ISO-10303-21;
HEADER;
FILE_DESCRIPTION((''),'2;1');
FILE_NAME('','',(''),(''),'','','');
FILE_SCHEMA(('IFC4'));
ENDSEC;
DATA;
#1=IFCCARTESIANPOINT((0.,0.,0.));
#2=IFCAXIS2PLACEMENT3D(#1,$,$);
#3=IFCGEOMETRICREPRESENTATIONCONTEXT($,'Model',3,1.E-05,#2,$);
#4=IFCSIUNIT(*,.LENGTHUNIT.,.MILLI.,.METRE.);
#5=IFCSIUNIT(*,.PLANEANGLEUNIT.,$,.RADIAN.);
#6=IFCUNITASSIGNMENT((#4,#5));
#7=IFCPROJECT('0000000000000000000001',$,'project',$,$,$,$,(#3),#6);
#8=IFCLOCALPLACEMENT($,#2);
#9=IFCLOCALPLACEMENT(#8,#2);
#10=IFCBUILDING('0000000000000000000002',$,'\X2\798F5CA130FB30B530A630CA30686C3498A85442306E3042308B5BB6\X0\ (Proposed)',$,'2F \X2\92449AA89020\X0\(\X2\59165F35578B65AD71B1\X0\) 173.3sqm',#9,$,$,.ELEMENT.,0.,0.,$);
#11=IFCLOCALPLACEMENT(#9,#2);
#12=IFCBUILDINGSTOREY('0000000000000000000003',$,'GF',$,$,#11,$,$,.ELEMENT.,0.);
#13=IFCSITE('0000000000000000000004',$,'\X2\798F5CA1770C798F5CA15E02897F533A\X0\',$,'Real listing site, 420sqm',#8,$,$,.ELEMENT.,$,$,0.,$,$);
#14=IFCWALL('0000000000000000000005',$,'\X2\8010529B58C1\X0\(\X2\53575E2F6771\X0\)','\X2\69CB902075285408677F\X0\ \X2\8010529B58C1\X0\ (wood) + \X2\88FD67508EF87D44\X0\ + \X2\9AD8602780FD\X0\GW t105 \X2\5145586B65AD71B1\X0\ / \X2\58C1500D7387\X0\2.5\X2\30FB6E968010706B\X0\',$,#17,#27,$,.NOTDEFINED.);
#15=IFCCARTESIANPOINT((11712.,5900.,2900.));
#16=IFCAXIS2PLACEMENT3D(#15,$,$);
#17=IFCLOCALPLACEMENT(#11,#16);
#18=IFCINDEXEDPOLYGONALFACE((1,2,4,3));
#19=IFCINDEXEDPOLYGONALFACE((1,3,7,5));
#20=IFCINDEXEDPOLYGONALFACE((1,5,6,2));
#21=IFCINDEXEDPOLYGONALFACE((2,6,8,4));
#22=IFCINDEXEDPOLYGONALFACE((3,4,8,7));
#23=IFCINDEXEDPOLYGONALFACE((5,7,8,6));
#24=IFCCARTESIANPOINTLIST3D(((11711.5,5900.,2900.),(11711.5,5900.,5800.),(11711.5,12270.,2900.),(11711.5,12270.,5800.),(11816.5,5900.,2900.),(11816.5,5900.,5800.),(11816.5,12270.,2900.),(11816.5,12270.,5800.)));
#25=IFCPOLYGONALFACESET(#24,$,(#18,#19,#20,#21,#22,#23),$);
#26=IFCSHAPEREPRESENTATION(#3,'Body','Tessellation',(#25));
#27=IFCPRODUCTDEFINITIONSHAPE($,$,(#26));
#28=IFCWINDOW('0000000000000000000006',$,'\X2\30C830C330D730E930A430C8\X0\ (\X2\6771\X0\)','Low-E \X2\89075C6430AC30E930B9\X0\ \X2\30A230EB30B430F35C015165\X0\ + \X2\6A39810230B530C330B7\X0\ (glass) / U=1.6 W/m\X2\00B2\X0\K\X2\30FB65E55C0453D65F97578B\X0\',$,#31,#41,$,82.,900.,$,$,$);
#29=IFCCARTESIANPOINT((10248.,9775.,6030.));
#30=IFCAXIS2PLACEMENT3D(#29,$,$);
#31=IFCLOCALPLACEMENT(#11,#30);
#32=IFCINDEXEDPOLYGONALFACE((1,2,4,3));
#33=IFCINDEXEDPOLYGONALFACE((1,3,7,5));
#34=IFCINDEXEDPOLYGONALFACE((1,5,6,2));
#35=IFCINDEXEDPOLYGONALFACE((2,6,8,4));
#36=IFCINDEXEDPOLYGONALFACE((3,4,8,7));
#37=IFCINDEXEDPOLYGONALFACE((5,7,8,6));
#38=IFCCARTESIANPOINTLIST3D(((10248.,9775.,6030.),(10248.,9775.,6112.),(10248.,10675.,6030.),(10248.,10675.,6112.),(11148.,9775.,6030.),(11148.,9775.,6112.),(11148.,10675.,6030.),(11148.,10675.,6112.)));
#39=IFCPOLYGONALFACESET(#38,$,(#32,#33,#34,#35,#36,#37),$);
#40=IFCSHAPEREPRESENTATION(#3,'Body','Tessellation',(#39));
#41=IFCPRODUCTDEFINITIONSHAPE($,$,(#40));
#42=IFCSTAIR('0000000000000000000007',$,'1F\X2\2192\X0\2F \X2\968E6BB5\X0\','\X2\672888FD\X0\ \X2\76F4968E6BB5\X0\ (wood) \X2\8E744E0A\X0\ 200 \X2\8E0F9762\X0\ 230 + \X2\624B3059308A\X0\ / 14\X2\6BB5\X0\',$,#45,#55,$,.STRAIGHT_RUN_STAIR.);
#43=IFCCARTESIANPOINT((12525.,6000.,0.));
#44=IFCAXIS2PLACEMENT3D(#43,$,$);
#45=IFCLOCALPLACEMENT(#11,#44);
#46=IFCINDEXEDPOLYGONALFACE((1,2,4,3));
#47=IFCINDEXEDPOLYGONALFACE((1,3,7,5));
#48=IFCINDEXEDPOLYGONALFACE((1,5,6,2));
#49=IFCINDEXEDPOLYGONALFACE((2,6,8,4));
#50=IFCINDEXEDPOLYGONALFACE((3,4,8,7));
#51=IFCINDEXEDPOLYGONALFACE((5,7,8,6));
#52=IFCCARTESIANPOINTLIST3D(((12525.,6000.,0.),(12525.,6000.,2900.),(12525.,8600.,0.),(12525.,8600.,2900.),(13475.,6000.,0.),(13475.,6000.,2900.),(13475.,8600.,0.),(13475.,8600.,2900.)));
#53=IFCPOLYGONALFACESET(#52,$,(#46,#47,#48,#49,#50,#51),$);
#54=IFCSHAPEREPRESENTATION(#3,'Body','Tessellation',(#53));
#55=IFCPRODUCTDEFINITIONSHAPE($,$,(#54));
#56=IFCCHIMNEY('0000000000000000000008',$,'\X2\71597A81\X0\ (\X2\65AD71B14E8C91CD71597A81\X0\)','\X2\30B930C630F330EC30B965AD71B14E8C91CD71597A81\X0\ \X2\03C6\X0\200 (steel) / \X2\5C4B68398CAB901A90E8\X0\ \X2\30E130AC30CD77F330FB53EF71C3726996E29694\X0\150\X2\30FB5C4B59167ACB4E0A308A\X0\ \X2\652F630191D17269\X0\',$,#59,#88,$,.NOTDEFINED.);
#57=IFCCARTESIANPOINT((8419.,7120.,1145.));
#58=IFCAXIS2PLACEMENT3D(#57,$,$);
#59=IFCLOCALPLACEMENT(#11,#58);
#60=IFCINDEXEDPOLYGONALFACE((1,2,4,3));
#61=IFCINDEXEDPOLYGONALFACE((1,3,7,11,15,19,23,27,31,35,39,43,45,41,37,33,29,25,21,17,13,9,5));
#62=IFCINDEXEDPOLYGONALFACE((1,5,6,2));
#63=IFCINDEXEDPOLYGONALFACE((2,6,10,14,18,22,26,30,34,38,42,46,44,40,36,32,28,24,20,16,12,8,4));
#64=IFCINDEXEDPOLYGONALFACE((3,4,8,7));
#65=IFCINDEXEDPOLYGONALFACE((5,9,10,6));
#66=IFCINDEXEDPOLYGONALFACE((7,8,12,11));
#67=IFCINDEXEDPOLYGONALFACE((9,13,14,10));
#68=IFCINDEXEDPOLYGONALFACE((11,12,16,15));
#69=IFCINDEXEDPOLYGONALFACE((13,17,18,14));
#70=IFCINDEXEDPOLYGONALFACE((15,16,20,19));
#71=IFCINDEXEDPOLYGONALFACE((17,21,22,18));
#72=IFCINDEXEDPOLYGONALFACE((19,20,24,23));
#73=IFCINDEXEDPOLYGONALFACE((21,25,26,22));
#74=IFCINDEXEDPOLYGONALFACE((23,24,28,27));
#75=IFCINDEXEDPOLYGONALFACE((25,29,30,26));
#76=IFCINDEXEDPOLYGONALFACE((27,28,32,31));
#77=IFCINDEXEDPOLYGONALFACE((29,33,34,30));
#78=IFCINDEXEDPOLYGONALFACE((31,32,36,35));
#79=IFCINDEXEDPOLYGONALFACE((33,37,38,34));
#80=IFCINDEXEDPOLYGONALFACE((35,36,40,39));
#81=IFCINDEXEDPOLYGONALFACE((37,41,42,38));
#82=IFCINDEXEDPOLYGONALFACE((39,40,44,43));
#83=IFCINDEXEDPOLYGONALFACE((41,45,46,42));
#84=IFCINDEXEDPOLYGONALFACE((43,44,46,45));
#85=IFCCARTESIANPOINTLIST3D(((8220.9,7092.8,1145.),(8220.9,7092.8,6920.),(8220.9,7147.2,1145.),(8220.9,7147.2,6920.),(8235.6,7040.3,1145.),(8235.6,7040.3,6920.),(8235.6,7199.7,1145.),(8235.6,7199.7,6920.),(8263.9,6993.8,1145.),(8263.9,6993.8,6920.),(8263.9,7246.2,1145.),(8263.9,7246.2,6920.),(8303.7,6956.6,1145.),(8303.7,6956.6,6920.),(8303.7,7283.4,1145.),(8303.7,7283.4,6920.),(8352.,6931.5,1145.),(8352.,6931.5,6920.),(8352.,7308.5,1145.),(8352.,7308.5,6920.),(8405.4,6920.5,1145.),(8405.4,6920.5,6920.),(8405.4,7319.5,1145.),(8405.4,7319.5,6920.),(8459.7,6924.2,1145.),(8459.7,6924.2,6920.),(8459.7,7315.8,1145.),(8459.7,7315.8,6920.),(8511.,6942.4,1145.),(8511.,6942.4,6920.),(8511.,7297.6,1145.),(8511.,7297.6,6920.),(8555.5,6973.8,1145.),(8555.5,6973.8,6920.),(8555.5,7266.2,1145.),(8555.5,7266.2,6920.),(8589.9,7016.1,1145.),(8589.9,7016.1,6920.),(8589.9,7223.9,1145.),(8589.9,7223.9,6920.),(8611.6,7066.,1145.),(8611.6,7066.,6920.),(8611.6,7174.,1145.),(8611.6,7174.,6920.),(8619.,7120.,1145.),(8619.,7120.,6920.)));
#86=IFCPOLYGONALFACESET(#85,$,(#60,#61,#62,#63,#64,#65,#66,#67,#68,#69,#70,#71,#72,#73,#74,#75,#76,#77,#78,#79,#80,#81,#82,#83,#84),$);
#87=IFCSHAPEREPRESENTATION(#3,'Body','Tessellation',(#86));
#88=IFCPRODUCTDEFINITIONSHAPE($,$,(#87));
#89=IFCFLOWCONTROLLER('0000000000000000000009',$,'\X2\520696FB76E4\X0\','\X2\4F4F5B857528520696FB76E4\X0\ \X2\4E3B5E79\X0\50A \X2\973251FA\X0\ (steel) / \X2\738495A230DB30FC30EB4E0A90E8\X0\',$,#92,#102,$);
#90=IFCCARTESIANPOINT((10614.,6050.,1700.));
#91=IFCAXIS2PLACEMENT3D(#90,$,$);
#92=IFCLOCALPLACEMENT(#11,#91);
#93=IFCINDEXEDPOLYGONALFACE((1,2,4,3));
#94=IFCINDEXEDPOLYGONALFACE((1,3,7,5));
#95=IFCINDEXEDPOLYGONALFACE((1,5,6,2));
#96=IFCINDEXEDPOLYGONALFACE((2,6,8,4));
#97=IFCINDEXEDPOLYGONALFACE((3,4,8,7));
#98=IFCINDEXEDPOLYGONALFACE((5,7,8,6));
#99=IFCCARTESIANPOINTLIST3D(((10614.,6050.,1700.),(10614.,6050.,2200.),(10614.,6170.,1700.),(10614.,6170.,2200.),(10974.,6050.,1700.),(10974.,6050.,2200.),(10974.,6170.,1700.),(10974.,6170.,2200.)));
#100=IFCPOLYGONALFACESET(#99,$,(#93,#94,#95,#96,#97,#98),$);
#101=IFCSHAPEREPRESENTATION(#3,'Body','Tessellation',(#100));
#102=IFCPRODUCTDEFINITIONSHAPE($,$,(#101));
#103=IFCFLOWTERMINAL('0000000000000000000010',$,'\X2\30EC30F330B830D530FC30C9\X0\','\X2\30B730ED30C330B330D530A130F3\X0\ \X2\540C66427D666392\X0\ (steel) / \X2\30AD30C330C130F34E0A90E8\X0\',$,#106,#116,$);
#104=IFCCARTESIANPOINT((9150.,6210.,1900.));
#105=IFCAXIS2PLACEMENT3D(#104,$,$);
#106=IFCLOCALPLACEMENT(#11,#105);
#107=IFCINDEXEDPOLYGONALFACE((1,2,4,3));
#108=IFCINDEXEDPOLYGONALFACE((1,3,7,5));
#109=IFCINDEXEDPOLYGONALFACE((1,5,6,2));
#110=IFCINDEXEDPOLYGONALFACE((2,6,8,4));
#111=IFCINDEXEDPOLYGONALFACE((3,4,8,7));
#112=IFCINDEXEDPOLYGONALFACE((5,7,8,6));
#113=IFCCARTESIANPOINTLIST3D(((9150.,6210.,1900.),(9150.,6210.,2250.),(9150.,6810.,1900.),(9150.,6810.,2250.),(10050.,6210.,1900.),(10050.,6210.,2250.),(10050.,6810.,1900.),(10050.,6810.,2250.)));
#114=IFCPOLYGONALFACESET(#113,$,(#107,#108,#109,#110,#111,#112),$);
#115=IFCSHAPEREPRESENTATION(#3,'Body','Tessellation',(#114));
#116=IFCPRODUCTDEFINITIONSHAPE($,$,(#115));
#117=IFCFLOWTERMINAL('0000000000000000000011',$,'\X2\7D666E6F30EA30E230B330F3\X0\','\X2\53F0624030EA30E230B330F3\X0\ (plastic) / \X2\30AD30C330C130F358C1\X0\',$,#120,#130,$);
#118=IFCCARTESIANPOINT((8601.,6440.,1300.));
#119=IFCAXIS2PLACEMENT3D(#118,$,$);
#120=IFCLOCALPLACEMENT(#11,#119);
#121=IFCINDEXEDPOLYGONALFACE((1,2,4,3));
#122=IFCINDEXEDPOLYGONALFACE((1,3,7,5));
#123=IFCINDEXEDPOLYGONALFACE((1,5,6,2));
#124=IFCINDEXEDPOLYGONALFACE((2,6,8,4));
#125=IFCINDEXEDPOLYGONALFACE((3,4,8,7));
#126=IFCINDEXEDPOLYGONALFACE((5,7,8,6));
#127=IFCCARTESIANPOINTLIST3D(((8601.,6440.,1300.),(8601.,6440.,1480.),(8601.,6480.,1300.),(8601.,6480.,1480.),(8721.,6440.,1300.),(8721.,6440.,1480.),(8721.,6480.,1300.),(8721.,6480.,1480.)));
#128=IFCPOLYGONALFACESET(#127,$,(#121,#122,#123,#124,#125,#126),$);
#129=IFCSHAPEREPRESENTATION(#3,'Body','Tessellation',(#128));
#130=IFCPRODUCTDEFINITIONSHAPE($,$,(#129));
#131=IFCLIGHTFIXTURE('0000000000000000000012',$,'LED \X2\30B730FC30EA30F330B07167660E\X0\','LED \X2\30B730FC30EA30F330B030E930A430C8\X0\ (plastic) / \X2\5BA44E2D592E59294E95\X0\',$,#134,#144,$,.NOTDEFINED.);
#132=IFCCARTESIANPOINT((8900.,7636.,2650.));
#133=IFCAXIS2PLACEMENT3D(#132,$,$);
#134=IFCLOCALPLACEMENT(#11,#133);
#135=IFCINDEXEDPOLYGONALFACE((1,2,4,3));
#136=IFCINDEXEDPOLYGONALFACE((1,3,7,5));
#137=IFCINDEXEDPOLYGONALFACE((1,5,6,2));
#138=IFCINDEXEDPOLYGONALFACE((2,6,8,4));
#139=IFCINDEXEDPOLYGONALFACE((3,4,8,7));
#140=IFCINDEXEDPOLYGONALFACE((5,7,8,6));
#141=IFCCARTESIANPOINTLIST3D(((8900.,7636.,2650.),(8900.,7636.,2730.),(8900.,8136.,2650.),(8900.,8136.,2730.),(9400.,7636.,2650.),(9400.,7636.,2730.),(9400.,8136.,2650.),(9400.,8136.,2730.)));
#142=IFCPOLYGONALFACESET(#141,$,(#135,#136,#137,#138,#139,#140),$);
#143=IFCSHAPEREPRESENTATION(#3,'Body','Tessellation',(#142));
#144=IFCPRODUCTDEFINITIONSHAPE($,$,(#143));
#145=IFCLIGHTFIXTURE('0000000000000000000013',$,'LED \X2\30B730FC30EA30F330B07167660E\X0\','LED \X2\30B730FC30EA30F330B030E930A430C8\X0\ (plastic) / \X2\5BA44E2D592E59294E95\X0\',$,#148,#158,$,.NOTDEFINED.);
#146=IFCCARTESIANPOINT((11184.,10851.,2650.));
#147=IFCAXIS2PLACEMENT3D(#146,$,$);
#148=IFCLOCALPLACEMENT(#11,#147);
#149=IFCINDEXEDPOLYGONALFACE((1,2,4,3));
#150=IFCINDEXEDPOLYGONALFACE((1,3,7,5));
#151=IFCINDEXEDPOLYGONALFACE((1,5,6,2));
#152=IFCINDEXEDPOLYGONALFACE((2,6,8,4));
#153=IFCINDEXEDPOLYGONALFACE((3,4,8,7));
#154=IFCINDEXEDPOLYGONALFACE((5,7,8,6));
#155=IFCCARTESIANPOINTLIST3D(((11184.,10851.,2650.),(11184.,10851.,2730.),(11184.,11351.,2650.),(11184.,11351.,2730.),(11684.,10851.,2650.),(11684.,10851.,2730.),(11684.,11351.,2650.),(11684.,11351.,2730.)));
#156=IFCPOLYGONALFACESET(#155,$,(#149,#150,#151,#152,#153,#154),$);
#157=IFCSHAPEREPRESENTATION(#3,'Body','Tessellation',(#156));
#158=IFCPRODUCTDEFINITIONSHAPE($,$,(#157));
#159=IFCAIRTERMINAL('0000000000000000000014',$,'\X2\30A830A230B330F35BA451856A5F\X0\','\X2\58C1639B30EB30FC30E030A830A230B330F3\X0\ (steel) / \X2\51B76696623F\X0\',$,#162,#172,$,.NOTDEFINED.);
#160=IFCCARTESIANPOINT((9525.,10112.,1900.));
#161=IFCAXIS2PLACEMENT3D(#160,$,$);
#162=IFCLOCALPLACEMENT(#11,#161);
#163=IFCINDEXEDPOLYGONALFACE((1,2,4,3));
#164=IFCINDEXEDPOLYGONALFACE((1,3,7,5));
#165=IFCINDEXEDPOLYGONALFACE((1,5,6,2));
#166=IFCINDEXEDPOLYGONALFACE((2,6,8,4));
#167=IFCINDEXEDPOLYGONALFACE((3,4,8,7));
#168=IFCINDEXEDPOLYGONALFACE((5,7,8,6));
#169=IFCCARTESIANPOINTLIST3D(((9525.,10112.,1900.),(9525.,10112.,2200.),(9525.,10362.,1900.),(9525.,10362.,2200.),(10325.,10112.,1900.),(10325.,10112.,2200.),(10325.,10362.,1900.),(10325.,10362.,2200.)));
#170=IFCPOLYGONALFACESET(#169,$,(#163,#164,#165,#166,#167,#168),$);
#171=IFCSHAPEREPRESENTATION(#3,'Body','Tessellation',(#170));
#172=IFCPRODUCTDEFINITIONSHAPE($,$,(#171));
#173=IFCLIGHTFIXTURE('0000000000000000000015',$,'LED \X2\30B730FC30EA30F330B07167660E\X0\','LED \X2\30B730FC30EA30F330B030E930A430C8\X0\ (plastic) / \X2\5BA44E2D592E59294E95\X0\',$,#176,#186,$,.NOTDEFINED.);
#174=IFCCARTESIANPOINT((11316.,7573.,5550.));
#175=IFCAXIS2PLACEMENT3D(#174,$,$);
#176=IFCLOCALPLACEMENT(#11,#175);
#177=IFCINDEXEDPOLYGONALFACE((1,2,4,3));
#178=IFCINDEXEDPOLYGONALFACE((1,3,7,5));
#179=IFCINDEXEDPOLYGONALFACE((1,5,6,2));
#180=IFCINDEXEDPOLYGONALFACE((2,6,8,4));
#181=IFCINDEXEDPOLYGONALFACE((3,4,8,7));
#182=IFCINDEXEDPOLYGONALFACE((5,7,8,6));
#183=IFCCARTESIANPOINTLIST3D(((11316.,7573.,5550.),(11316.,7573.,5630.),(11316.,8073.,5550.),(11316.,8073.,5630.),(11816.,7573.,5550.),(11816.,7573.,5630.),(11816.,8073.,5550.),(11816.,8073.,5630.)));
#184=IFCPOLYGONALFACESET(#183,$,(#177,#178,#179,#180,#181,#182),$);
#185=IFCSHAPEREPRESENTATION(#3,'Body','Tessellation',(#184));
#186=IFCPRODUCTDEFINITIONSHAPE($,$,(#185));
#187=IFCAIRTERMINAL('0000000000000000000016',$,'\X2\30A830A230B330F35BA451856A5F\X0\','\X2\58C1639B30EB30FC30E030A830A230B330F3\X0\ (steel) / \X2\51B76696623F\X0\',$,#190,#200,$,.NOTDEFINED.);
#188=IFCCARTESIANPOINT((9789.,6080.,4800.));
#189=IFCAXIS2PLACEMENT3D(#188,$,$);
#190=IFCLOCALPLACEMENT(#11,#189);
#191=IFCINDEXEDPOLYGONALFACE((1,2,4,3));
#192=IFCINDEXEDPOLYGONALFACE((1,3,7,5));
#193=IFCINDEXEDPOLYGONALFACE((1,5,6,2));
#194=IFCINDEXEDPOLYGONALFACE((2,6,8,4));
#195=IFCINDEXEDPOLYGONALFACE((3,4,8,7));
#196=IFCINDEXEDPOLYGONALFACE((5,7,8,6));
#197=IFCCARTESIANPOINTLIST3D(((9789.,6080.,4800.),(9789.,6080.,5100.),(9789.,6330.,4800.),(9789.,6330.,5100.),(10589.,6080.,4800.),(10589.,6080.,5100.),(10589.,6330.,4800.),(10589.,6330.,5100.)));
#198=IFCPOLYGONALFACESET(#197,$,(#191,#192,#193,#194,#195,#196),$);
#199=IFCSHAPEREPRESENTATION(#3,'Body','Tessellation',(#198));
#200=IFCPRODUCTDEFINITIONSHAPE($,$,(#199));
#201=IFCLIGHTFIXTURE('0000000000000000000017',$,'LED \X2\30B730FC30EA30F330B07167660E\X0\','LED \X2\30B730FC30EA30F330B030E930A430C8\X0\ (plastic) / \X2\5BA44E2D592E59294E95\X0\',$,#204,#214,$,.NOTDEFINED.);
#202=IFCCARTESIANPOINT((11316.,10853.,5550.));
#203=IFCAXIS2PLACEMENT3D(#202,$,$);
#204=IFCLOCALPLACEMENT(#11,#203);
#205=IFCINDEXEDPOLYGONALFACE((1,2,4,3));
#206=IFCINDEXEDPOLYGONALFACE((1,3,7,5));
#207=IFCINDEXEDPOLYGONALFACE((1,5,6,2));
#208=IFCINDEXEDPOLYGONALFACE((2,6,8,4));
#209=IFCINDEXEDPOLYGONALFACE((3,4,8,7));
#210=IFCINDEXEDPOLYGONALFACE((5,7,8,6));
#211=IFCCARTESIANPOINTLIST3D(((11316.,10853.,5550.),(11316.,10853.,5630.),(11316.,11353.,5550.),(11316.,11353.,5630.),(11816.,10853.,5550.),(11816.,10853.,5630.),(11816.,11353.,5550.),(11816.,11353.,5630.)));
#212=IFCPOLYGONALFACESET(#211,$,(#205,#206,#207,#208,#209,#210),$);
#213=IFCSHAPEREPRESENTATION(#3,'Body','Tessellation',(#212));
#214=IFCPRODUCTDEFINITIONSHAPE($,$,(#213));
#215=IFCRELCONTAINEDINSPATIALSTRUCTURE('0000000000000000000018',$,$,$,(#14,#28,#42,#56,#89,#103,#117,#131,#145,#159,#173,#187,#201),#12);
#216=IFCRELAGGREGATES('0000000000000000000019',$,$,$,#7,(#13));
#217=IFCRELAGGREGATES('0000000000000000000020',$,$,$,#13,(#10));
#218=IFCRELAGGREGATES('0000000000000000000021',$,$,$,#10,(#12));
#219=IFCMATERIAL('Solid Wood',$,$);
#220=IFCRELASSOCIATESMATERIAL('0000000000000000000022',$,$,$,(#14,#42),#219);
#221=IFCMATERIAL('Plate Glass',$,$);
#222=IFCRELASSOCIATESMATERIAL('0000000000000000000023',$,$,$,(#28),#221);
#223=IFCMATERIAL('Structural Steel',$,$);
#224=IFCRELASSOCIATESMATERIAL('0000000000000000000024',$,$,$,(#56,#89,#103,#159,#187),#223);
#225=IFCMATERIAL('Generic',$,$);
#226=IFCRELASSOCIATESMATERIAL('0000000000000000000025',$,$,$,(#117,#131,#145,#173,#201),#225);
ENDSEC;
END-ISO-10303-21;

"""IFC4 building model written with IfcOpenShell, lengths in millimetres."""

from ifc_helpers import new_model, si_unit, frame, frame_2d, origin, origin_2d, place, context, project, spatial, rectangle, circle, extrude, material, element, save


model = new_model("IFC4")

# Units and contexts
model_context = context("Model", 3, precision=1e-05, world=origin())
ifc_project = project(units=[si_unit("LENGTHUNIT", "METRE", prefix="MILLI"), si_unit("PLANEANGLEUNIT", "RADIAN")], contexts=[model_context])

# Site, building, storey
site_placement = place(None, origin())
site = spatial("IfcSite", under=ifc_project, at=site_placement, Name="福岡県福岡市西区", ObjectType="Real listing site, 420sqm", CompositionType="ELEMENT", RefElevation=0.0)
building_placement = place(site_placement, origin())
building = spatial("IfcBuilding", under=site, at=building_placement, Name="福岡・サウナと水風呂のある家 (Proposed)", ObjectType="2F 鉄骨造(外張型断熱) 173.3sqm", CompositionType="ELEMENT", ElevationOfRefHeight=0.0, ElevationOfTerrain=0.0)
storey_placement = place(building_placement, origin())
storey = spatial("IfcBuildingStorey", under=building, at=storey_placement, Name="GF", CompositionType="ELEMENT", Elevation=0.0)

# Shared definitions
ifc_material_1 = material(Name="Solid Wood")

# Wall
wall_1_placement = place(storey_placement, frame((11712.0, 5900.0, 2900.0)))
element("IfcWall", 1, at=wall_1_placement, inside=storey, material=ifc_material_1, Name="耐力壁(南帯東)", Description="構造用合板 耐力壁 (wood) + 製材軸組 + 高性能GW t105 充填断熱 / 壁倍率2.5・準耐火", PredefinedType="NOTDEFINED", context=model_context, shape_type="SweptSolid", body=[
    extrude(rectangle(XDim=105.0, YDim=6370.0, at=frame_2d((52.0, 3185.0))), frame((11712.0, 5900.0, 2900.0)), (0.0, 0.0, 1.0), 2900.0),
])

# Window
ifc_material_2 = material(Name="Plate Glass")
window_placement = place(storey_placement, frame((10248.0, 9775.0, 6030.0)))
element("IfcWindow", 2, at=window_placement, inside=storey, material=ifc_material_2, Name="トップライト (東)", Description="Low-E 複層ガラス アルゴン封入 + 樹脂サッシ (glass) / U=1.6 W/m²K・日射取得型", OverallHeight=82.0, OverallWidth=900.0, context=model_context, shape_type="SweptSolid", body=[
    extrude(rectangle(XDim=900.0, YDim=900.0, at=frame_2d((450.0, 450.0))), frame((10248.0, 9775.0, 6030.0)), (0.0, 0.0, 1.0), 82.0),
])

# Stair
stair_placement = place(storey_placement, frame((12525.0, 6000.0, 0.0)))
element("IfcStair", 3, at=stair_placement, inside=storey, material=ifc_material_1, Name="1F→2F 階段", Description="木製 直階段 (wood) 蹴上 200 踏面 230 + 手すり / 14段", PredefinedType="STRAIGHT_RUN_STAIR", context=model_context, shape_type="SweptSolid", body=[
    extrude(rectangle(XDim=950.0, YDim=2600.0, at=frame_2d((475.0, 1300.0))), frame((12525.0, 6000.0, 0.0)), (0.0, 0.0, 1.0), 2900.0),
])

# Chimney
ifc_material_3 = material(Name="Structural Steel")
chimney_placement = place(storey_placement, frame((8419.0, 7120.0, 1145.0)))
element("IfcChimney", 4, at=chimney_placement, inside=storey, material=ifc_material_3, Name="煙突 (断熱二重煙突)", Description="ステンレス断熱二重煙突 φ200 (steel) / 屋根貫通部 メガネ石・可燃物離隔150・屋外立上り 支持金物", PredefinedType="NOTDEFINED", context=model_context, shape_type="SweptSolid", body=[
    extrude(circle(Radius=200.0, at=origin_2d()), frame((8419.0, 7120.0, 1145.0)), (0.0, 0.0, 1.0), 5775.0),
])

# Flow controller
flow_controller_placement = place(storey_placement, frame((10614.0, 6050.0, 1700.0)))
element("IfcFlowController", 5, at=flow_controller_placement, inside=storey, material=ifc_material_3, Name="分電盤", Description="住宅用分電盤 主幹50A 露出 (steel) / 玄関ホール上部", context=model_context, shape_type="SweptSolid", body=[
    extrude(rectangle(XDim=360.0, YDim=120.0, at=frame_2d((180.0, 60.0))), frame((10614.0, 6050.0, 1700.0)), (0.0, 0.0, 1.0), 500.0),
])

# Flow terminals
flow_terminal_1_placement = place(storey_placement, frame((9150.0, 6210.0, 1900.0)))
element("IfcFlowTerminal", 6, at=flow_terminal_1_placement, inside=storey, material=ifc_material_3, Name="レンジフード", Description="シロッコファン 同時給排 (steel) / キッチン上部", context=model_context, shape_type="SweptSolid", body=[
    extrude(rectangle(XDim=900.0, YDim=600.0, at=frame_2d((450.0, 300.0))), frame((9150.0, 6210.0, 1900.0)), (0.0, 0.0, 1.0), 350.0),
])
ifc_material_4 = material(Name="Generic")
flow_terminal_2_placement = place(storey_placement, frame((8601.0, 6440.0, 1300.0)))
element("IfcFlowTerminal", 7, at=flow_terminal_2_placement, inside=storey, material=ifc_material_4, Name="給湯リモコン", Description="台所リモコン (plastic) / キッチン壁", context=model_context, shape_type="SweptSolid", body=[
    extrude(rectangle(XDim=120.0, YDim=40.0, at=frame_2d((60.0, 20.0))), frame((8601.0, 6440.0, 1300.0)), (0.0, 0.0, 1.0), 180.0),
])

# Light fixtures
light_fixture_1_placement = place(storey_placement, frame((8900.0, 7636.0, 2650.0)))
element("IfcLightFixture", 8, at=light_fixture_1_placement, inside=storey, material=ifc_material_4, Name="LED シーリング照明", Description="LED シーリングライト (plastic) / 室中央天井", PredefinedType="NOTDEFINED", context=model_context, shape_type="SweptSolid", body=[
    extrude(rectangle(XDim=500.0, YDim=500.0, at=frame_2d((250.0, 250.0))), frame((8900.0, 7636.0, 2650.0)), (0.0, 0.0, 1.0), 80.0),
])
light_fixture_2_placement = place(storey_placement, frame((11184.0, 10851.0, 2650.0)))
element("IfcLightFixture", 9, at=light_fixture_2_placement, inside=storey, material=ifc_material_4, Name="LED シーリング照明", Description="LED シーリングライト (plastic) / 室中央天井", PredefinedType="NOTDEFINED", context=model_context, shape_type="SweptSolid", body=[
    extrude(rectangle(XDim=500.0, YDim=500.0, at=frame_2d((250.0, 250.0))), frame((11184.0, 10851.0, 2650.0)), (0.0, 0.0, 1.0), 80.0),
])

# Air terminal
air_terminal_1_placement = place(storey_placement, frame((9525.0, 10112.0, 1900.0)))
element("IfcAirTerminal", 10, at=air_terminal_1_placement, inside=storey, material=ifc_material_3, Name="エアコン室内機", Description="壁掛ルームエアコン (steel) / 冷暖房", PredefinedType="NOTDEFINED", context=model_context, shape_type="SweptSolid", body=[
    extrude(rectangle(XDim=800.0, YDim=250.0, at=frame_2d((400.0, 125.0))), frame((9525.0, 10112.0, 1900.0)), (0.0, 0.0, 1.0), 300.0),
])

# Light fixture
light_fixture_3_placement = place(storey_placement, frame((11316.0, 7573.0, 5550.0)))
element("IfcLightFixture", 11, at=light_fixture_3_placement, inside=storey, material=ifc_material_4, Name="LED シーリング照明", Description="LED シーリングライト (plastic) / 室中央天井", PredefinedType="NOTDEFINED", context=model_context, shape_type="SweptSolid", body=[
    extrude(rectangle(XDim=500.0, YDim=500.0, at=frame_2d((250.0, 250.0))), frame((11316.0, 7573.0, 5550.0)), (0.0, 0.0, 1.0), 80.0),
])

# Air terminal
air_terminal_2_placement = place(storey_placement, frame((9789.0, 6080.0, 4800.0)))
element("IfcAirTerminal", 12, at=air_terminal_2_placement, inside=storey, material=ifc_material_3, Name="エアコン室内機", Description="壁掛ルームエアコン (steel) / 冷暖房", PredefinedType="NOTDEFINED", context=model_context, shape_type="SweptSolid", body=[
    extrude(rectangle(XDim=800.0, YDim=250.0, at=frame_2d((400.0, 125.0))), frame((9789.0, 6080.0, 4800.0)), (0.0, 0.0, 1.0), 300.0),
])

# Light fixture
light_fixture_4_placement = place(storey_placement, frame((11316.0, 10853.0, 5550.0)))
element("IfcLightFixture", 13, at=light_fixture_4_placement, inside=storey, material=ifc_material_4, Name="LED シーリング照明", Description="LED シーリングライト (plastic) / 室中央天井", PredefinedType="NOTDEFINED", context=model_context, shape_type="SweptSolid", body=[
    extrude(rectangle(XDim=500.0, YDim=500.0, at=frame_2d((250.0, 250.0))), frame((11316.0, 10853.0, 5550.0)), (0.0, 0.0, 1.0), 80.0),
])

save(model, "model.ifc")
